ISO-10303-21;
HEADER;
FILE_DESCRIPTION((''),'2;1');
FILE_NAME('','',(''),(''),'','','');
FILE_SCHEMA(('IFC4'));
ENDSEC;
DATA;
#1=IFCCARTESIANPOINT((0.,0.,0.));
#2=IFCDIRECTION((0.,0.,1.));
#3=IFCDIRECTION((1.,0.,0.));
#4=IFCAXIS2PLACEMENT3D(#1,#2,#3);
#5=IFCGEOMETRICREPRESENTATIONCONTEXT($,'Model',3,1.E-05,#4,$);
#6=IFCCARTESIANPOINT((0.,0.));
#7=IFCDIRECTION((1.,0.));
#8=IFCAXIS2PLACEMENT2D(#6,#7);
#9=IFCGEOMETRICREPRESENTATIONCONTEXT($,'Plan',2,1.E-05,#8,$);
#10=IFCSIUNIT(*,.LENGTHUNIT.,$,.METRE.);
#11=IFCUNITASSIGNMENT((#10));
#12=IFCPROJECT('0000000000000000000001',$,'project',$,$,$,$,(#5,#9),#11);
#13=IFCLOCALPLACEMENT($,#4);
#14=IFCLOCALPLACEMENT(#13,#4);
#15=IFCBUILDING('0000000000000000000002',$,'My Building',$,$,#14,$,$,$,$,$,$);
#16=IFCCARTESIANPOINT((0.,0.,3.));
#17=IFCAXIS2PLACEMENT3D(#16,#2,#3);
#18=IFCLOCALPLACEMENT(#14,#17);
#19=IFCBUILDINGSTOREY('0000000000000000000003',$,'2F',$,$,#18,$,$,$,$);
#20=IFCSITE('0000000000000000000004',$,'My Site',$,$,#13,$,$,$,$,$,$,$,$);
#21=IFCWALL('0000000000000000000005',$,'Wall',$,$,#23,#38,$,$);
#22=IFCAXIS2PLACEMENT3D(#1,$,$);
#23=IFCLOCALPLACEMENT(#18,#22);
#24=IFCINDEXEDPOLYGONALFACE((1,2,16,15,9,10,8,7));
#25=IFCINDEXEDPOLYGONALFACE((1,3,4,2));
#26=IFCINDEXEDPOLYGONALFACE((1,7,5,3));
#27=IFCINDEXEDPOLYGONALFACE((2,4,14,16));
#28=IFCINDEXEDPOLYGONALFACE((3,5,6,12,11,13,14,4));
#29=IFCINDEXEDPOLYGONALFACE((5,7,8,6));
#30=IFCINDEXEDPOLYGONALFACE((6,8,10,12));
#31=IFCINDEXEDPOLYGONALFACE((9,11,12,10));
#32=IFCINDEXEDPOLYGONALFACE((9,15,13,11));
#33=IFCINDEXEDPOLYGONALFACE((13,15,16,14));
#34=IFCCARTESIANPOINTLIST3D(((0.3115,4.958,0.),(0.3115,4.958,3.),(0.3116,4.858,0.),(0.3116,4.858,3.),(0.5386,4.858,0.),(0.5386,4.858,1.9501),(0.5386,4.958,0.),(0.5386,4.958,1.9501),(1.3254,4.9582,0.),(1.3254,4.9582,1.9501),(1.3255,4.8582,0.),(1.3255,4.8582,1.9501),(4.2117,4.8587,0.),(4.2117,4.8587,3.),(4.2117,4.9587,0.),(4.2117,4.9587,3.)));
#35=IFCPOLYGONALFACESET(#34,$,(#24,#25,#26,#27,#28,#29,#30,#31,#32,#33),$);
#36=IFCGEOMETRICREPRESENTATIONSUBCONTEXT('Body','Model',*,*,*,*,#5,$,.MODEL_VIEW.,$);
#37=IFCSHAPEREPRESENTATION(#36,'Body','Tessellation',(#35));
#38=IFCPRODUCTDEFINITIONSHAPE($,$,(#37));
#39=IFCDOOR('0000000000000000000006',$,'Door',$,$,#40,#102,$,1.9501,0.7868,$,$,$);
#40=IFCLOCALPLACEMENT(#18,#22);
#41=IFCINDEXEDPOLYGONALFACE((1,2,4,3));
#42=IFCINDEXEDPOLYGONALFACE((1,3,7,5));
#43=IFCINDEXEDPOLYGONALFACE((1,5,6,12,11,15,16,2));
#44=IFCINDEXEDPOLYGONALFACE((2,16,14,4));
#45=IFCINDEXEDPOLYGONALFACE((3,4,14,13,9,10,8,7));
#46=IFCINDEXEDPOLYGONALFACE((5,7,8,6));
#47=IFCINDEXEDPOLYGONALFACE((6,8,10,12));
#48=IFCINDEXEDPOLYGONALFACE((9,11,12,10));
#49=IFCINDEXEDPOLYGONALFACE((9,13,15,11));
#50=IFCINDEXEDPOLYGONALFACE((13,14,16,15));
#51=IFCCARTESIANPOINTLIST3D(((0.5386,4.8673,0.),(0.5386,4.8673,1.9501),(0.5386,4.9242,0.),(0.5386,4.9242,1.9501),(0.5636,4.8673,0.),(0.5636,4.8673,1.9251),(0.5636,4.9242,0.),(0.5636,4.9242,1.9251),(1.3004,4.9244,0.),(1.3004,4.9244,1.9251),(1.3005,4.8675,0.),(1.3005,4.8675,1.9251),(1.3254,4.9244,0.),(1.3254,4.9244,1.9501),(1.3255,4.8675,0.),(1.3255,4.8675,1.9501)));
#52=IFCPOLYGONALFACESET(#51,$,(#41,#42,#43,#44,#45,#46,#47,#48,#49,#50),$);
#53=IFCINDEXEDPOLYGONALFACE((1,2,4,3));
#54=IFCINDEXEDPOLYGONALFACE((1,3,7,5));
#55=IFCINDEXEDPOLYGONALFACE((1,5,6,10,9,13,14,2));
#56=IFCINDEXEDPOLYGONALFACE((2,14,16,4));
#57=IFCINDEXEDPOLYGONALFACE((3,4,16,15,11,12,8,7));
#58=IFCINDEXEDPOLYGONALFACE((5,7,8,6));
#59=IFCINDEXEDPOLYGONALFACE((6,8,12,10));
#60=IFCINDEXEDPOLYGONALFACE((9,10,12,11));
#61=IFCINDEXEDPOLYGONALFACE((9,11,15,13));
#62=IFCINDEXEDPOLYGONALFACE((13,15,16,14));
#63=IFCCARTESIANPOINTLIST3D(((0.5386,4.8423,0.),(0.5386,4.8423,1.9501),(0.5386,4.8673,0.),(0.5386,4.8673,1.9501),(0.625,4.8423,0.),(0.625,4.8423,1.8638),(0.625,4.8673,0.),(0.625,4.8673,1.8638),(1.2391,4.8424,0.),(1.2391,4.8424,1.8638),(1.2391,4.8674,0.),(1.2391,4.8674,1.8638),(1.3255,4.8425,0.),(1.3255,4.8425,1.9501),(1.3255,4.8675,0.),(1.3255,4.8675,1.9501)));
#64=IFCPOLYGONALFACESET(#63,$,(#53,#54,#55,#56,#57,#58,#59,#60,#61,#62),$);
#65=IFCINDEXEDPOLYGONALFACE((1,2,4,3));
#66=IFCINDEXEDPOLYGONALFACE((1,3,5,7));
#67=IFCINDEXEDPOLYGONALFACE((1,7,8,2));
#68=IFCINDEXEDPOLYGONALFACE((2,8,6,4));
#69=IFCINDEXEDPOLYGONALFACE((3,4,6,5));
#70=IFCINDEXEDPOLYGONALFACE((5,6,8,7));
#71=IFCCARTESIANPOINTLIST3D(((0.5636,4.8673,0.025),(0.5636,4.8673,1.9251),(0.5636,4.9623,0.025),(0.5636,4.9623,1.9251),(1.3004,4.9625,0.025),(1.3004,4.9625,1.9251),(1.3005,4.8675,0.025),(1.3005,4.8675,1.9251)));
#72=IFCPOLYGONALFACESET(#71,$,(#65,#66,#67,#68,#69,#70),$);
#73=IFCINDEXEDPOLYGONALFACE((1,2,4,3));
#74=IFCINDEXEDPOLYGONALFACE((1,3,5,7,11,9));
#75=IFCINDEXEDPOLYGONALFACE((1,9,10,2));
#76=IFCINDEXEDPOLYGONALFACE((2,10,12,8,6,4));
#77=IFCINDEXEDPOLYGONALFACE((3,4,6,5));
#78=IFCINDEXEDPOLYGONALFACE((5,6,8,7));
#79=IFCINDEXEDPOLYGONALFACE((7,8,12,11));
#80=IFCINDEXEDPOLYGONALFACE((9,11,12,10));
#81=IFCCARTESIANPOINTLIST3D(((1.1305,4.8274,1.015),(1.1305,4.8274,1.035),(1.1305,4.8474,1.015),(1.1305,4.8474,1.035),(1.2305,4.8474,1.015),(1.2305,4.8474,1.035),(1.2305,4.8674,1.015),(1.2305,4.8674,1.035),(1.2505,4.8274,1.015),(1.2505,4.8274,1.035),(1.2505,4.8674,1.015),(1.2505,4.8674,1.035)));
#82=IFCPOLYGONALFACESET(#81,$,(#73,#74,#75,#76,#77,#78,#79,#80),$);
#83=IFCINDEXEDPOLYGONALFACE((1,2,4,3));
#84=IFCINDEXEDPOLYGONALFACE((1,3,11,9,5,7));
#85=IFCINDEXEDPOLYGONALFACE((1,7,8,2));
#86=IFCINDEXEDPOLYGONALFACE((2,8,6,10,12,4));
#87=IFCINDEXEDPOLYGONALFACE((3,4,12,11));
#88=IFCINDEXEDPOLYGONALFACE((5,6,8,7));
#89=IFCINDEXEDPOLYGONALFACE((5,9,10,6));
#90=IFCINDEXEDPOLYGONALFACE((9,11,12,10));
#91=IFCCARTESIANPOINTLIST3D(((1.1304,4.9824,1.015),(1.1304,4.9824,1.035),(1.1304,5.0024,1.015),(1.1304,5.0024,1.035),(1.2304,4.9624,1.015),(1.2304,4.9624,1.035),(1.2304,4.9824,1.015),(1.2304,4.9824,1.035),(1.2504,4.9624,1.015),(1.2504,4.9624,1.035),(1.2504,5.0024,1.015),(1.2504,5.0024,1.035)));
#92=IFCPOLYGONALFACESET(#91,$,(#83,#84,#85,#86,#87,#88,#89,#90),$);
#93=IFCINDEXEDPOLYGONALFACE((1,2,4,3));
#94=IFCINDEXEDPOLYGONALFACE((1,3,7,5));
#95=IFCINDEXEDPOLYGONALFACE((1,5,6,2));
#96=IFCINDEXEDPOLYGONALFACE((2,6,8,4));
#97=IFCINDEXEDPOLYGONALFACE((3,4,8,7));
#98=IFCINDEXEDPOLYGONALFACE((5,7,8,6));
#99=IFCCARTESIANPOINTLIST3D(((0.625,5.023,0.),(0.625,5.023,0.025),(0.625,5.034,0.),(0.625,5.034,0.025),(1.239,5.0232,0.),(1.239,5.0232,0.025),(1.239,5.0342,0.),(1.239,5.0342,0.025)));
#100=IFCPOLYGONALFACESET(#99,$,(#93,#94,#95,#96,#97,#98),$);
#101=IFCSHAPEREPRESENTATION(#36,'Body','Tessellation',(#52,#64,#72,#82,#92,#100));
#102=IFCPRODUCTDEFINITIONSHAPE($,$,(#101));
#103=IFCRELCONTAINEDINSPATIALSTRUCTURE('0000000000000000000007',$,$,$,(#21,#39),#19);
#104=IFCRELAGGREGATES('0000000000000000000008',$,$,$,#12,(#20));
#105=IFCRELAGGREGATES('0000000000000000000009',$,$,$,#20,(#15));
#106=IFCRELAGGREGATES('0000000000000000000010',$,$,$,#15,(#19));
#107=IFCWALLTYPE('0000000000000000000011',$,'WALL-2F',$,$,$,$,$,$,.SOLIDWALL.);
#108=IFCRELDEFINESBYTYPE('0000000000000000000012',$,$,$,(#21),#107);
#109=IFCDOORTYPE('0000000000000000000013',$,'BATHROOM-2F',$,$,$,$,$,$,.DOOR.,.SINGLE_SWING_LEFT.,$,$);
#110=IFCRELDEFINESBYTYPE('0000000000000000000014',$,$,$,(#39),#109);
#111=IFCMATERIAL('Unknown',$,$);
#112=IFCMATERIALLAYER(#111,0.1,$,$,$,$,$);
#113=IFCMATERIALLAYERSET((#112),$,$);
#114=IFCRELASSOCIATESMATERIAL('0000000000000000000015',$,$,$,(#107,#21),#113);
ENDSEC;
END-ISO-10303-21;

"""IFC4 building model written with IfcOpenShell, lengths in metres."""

from ifc_helpers import new_model, entity, si_unit, frame, origin_with_axes, origin_2d_with_axis, place, context, subcontext, project, spatial, line, indexed_curve, outline, extrude, shape, source, transform, mapped, material, layer, layer_set, layer_usage, type_object, type_shapes, element, fill, save


model = new_model("IFC4")

# Units and contexts
model_context = context("Model", 3, precision=1e-05, world=origin_with_axes())
plan_context = context("Plan", 2, precision=1e-05, world=origin_2d_with_axis())
body_context_1 = subcontext(model_context, "Body", "Model", "MODEL_VIEW")
body_context_2 = subcontext(plan_context, "Body", "Plan", "PLAN_VIEW")
ifc_project = project(units=[si_unit("LENGTHUNIT", "METRE")], contexts=[model_context, plan_context])

# Site, building, storey
site_placement = place(None, origin_with_axes())
site = spatial("IfcSite", under=ifc_project, at=site_placement, Name="My Site")
building_placement = place(site_placement, origin_with_axes())
building = spatial("IfcBuilding", under=site, at=building_placement, Name="My Building")
storey_placement = place(building_placement, frame((0.0, 0.0, 3.0), z_axis=(0.0, 0.0, 1.0), x_axis=(1.0, 0.0, 0.0)))
storey = spatial("IfcBuildingStorey", under=building, at=storey_placement, Name="2F")

# Shared definitions
ifc_material = material(Name="Unknown")

# Shared definitions
ifc_layer_1 = layer(ifc_material, 0.1)
ifc_layer_set_1 = layer_set([ifc_layer_1])
wall_type = type_object("IfcWallType", Name="WALL-2F", PredefinedType="SOLIDWALL", material=ifc_layer_set_1)

# Wall, opening, door
ifc_layer_usage_1 = layer_usage(ifc_layer_set_1, "AXIS2", "POSITIVE", 0.0)
wall_1_placement = place(storey_placement, frame((4.2117, 4.9587, 0.0), z_axis=(0.0, 0.0, 1.0), x_axis=(-1.0, -0.000176, 0.0)))
wall_1 = element("IfcWall", 1, at=wall_1_placement, inside=storey, type_object=wall_type, material=ifc_layer_usage_1, Name="Wall", context=body_context_1, shape_type="SweptSolid", body=[
    extrude(outline(indexed_curve([(0.0, 0.0), (0.0, 0.1), (3.9002, 0.1), (3.9002, 0.0)], segments=[line(1, 2, 3, 4, 1)])), origin_with_axes(), (0.0, 0.0, 1.0), 3.0),
])
shared_shape_1 = source(origin_with_axes(), body_context_1, "Body", "SweptSolid", [
    extrude(outline(indexed_curve([(0.0, 0.0), (0.7868, 0.0), (0.7868, 1.9501), (0.0, 1.9501)], segments=[line(1, 2, 3, 4, 1)])), frame((0.0, -0.6, 0.0), z_axis=(0.0, -1.0, 0.0), x_axis=(1.0, 0.0, 0.0)), (0.0, 0.0, -1.0), 1.2),
])
opening_1_placement = place(wall_1_placement, frame((3.6731, 0.1, 0.0), z_axis=(0.0, 0.0, 1.0), x_axis=(-1.0, 0.0, 0.0)))
opening_1 = element("IfcOpeningElement", 2, at=opening_1_placement, cuts=wall_1, PredefinedType="OPENING", context=body_context_1, shape_type="MappedRepresentation", body=[
    mapped(shared_shape_1, transform((0.0, 0.0, 0.0), x_axis=(1.0, 0.0, 0.0), y_axis=(0.0, 1.0, 0.0), z_axis=(0.0, 0.0, 1.0), scale=1.0)),
])
door_type_1 = type_object("IfcDoorType", Name="BATHROOM-2F", OperationType="SINGLE_SWING_LEFT", PredefinedType="DOOR")
shared_shape_2 = source(origin_with_axes(), body_context_1, "Body", "SweptSolid", [
    extrude(outline(indexed_curve([(0.0, 0.0), (0.0, 1.9501), (0.7868, 1.9501), (0.7868, 0.0), (0.7618, 0.0), (0.7618, 1.9251), (0.025, 1.9251), (0.025, 0.0)], segments=[line(1, 2, 3, 4, 5, 6, 7, 8, 1)])), frame((0.0, 0.0093, 0.0), z_axis=(0.0, -1.0, 0.0), x_axis=(1.0, 0.0, 0.0)), (0.0, 0.0, -1.0), 0.0569),
    extrude(outline(indexed_curve([(0.0, 0.0), (0.0, 1.9501), (0.7868, 1.9501), (0.7868, 0.0), (0.7005, 0.0), (0.7005, 1.8638), (0.0864, 1.8638), (0.0864, 0.0)], segments=[line(1, 2, 3, 4, 5, 6, 7, 8, 1)])), frame((0.0, -0.0157, 0.0), z_axis=(0.0, -1.0, 0.0), x_axis=(1.0, 0.0, 0.0)), (0.0, 0.0, -1.0), 0.025),
    extrude(outline(indexed_curve([(0.0, 0.0), (0.7368, 0.0), (0.7368, 0.095), (0.0, 0.095)], segments=[line(1, 2, 3, 4, 1)])), frame((0.025, 0.0093, 0.025), z_axis=(0.0, 0.0, 1.0), x_axis=(1.0, 0.0, 0.0)), (0.0, 0.0, 1.0), 1.9001),
    extrude(outline(indexed_curve([(0.0, 0.0), (0.0, -0.04), (-0.12, -0.04), (-0.12, -0.02), (-0.02, -0.02), (-0.02, 0.0)], segments=[line(1, 2, 3, 4, 5, 6, 1)])), frame((0.7118, 0.0093, 1.015), z_axis=(0.0, 0.0, 1.0), x_axis=(1.0, 0.0, 0.0)), (0.0, 0.0, 1.0), 0.02),
    extrude(outline(indexed_curve([(0.0, 0.0), (0.0, 0.04), (-0.12, 0.04), (-0.12, 0.02), (-0.02, 0.02), (-0.02, 0.0)], segments=[line(1, 2, 3, 4, 5, 6, 1)])), frame((0.7118, 0.1043, 1.015), z_axis=(0.0, 0.0, 1.0), x_axis=(1.0, 0.0, 0.0)), (0.0, 0.0, 1.0), 0.02),
    extrude(outline(indexed_curve([(0.0, 0.0), (0.6141, 0.0), (0.6141, 0.011), (0.0, 0.011)], segments=[line(1, 2, 3, 4, 1)])), frame((0.0864, 0.165, 0.0), z_axis=(0.0, 0.0, 1.0), x_axis=(1.0, 0.0, 0.0)), (0.0, 0.0, 1.0), 0.025),
])
shared_shape_3 = source(origin_with_axes(), body_context_2, "Body", "Curve2D", [
    entity("IfcIndexedPolyCurve", entity("IfcCartesianPointList2D", [[0.0, -0.0157], [0.0, 0.0662], [0.025, 0.0662], [0.025, 0.0093], [0.0864, 0.0093], [0.0864, -0.0157]]), [entity("IfcLineIndex", [1, 2, 3, 4, 5, 6, 1])]),
    entity("IfcIndexedPolyCurve", entity("IfcCartesianPointList2D", [[0.7868, -0.0157], [0.7868, 0.0662], [0.7618, 0.0662], [0.7618, 0.0093], [0.7005, 0.0093], [0.7005, -0.0157]]), [entity("IfcLineIndex", [1, 2, 3, 4, 5, 6, 1])]),
    entity("IfcTrimmedCurve", entity("IfcEllipse", entity("IfcAxis2Placement2D", entity("IfcCartesianPoint", [0.12, 0.0662]), entity("IfcDirection", [1.0, 0.0])), 0.6418, 0.7368), [entity("IfcCartesianPoint", [0.7618, 0.0662])], [entity("IfcCartesianPoint", [0.12, 0.803])], True, "CARTESIAN"),
    entity("IfcIndexedPolyCurve", entity("IfcCartesianPointList2D", [[0.025, 0.0662], [0.12, 0.0662], [0.12, 0.803], [0.025, 0.803]]), [entity("IfcLineIndex", [1, 2, 3, 4, 1])]),
])
type_shapes(door_type_1, [shared_shape_2, shared_shape_3])
door_1_placement = place(opening_1_placement, frame((0.0, 0.0, 0.0), z_axis=(0.0, 0.0, 1.0), x_axis=(1.0, 0.0, 0.0)))
door_1 = element("IfcDoor", 3, at=door_1_placement, inside=storey, type_object=door_type_1, Name="Door", OverallHeight=1.9501, OverallWidth=0.7868, shapes=[
    shape(body_context_1, "Body", "MappedRepresentation", [mapped(shared_shape_2, transform((0.0, 0.0, 0.0), x_axis=(1.0, 0.0, 0.0), y_axis=(0.0, 1.0, 0.0), z_axis=(0.0, 0.0, 1.0), scale=1.0))]),
    shape(body_context_2, "Body", "MappedRepresentation", [mapped(shared_shape_3, transform((0.0, 0.0, 0.0), x_axis=(1.0, 0.0, 0.0), y_axis=(0.0, 1.0, 0.0), z_axis=(0.0, 0.0, 1.0), scale=1.0))]),
])
fill(opening_1, door_1)

save(model, "model.ifc")
